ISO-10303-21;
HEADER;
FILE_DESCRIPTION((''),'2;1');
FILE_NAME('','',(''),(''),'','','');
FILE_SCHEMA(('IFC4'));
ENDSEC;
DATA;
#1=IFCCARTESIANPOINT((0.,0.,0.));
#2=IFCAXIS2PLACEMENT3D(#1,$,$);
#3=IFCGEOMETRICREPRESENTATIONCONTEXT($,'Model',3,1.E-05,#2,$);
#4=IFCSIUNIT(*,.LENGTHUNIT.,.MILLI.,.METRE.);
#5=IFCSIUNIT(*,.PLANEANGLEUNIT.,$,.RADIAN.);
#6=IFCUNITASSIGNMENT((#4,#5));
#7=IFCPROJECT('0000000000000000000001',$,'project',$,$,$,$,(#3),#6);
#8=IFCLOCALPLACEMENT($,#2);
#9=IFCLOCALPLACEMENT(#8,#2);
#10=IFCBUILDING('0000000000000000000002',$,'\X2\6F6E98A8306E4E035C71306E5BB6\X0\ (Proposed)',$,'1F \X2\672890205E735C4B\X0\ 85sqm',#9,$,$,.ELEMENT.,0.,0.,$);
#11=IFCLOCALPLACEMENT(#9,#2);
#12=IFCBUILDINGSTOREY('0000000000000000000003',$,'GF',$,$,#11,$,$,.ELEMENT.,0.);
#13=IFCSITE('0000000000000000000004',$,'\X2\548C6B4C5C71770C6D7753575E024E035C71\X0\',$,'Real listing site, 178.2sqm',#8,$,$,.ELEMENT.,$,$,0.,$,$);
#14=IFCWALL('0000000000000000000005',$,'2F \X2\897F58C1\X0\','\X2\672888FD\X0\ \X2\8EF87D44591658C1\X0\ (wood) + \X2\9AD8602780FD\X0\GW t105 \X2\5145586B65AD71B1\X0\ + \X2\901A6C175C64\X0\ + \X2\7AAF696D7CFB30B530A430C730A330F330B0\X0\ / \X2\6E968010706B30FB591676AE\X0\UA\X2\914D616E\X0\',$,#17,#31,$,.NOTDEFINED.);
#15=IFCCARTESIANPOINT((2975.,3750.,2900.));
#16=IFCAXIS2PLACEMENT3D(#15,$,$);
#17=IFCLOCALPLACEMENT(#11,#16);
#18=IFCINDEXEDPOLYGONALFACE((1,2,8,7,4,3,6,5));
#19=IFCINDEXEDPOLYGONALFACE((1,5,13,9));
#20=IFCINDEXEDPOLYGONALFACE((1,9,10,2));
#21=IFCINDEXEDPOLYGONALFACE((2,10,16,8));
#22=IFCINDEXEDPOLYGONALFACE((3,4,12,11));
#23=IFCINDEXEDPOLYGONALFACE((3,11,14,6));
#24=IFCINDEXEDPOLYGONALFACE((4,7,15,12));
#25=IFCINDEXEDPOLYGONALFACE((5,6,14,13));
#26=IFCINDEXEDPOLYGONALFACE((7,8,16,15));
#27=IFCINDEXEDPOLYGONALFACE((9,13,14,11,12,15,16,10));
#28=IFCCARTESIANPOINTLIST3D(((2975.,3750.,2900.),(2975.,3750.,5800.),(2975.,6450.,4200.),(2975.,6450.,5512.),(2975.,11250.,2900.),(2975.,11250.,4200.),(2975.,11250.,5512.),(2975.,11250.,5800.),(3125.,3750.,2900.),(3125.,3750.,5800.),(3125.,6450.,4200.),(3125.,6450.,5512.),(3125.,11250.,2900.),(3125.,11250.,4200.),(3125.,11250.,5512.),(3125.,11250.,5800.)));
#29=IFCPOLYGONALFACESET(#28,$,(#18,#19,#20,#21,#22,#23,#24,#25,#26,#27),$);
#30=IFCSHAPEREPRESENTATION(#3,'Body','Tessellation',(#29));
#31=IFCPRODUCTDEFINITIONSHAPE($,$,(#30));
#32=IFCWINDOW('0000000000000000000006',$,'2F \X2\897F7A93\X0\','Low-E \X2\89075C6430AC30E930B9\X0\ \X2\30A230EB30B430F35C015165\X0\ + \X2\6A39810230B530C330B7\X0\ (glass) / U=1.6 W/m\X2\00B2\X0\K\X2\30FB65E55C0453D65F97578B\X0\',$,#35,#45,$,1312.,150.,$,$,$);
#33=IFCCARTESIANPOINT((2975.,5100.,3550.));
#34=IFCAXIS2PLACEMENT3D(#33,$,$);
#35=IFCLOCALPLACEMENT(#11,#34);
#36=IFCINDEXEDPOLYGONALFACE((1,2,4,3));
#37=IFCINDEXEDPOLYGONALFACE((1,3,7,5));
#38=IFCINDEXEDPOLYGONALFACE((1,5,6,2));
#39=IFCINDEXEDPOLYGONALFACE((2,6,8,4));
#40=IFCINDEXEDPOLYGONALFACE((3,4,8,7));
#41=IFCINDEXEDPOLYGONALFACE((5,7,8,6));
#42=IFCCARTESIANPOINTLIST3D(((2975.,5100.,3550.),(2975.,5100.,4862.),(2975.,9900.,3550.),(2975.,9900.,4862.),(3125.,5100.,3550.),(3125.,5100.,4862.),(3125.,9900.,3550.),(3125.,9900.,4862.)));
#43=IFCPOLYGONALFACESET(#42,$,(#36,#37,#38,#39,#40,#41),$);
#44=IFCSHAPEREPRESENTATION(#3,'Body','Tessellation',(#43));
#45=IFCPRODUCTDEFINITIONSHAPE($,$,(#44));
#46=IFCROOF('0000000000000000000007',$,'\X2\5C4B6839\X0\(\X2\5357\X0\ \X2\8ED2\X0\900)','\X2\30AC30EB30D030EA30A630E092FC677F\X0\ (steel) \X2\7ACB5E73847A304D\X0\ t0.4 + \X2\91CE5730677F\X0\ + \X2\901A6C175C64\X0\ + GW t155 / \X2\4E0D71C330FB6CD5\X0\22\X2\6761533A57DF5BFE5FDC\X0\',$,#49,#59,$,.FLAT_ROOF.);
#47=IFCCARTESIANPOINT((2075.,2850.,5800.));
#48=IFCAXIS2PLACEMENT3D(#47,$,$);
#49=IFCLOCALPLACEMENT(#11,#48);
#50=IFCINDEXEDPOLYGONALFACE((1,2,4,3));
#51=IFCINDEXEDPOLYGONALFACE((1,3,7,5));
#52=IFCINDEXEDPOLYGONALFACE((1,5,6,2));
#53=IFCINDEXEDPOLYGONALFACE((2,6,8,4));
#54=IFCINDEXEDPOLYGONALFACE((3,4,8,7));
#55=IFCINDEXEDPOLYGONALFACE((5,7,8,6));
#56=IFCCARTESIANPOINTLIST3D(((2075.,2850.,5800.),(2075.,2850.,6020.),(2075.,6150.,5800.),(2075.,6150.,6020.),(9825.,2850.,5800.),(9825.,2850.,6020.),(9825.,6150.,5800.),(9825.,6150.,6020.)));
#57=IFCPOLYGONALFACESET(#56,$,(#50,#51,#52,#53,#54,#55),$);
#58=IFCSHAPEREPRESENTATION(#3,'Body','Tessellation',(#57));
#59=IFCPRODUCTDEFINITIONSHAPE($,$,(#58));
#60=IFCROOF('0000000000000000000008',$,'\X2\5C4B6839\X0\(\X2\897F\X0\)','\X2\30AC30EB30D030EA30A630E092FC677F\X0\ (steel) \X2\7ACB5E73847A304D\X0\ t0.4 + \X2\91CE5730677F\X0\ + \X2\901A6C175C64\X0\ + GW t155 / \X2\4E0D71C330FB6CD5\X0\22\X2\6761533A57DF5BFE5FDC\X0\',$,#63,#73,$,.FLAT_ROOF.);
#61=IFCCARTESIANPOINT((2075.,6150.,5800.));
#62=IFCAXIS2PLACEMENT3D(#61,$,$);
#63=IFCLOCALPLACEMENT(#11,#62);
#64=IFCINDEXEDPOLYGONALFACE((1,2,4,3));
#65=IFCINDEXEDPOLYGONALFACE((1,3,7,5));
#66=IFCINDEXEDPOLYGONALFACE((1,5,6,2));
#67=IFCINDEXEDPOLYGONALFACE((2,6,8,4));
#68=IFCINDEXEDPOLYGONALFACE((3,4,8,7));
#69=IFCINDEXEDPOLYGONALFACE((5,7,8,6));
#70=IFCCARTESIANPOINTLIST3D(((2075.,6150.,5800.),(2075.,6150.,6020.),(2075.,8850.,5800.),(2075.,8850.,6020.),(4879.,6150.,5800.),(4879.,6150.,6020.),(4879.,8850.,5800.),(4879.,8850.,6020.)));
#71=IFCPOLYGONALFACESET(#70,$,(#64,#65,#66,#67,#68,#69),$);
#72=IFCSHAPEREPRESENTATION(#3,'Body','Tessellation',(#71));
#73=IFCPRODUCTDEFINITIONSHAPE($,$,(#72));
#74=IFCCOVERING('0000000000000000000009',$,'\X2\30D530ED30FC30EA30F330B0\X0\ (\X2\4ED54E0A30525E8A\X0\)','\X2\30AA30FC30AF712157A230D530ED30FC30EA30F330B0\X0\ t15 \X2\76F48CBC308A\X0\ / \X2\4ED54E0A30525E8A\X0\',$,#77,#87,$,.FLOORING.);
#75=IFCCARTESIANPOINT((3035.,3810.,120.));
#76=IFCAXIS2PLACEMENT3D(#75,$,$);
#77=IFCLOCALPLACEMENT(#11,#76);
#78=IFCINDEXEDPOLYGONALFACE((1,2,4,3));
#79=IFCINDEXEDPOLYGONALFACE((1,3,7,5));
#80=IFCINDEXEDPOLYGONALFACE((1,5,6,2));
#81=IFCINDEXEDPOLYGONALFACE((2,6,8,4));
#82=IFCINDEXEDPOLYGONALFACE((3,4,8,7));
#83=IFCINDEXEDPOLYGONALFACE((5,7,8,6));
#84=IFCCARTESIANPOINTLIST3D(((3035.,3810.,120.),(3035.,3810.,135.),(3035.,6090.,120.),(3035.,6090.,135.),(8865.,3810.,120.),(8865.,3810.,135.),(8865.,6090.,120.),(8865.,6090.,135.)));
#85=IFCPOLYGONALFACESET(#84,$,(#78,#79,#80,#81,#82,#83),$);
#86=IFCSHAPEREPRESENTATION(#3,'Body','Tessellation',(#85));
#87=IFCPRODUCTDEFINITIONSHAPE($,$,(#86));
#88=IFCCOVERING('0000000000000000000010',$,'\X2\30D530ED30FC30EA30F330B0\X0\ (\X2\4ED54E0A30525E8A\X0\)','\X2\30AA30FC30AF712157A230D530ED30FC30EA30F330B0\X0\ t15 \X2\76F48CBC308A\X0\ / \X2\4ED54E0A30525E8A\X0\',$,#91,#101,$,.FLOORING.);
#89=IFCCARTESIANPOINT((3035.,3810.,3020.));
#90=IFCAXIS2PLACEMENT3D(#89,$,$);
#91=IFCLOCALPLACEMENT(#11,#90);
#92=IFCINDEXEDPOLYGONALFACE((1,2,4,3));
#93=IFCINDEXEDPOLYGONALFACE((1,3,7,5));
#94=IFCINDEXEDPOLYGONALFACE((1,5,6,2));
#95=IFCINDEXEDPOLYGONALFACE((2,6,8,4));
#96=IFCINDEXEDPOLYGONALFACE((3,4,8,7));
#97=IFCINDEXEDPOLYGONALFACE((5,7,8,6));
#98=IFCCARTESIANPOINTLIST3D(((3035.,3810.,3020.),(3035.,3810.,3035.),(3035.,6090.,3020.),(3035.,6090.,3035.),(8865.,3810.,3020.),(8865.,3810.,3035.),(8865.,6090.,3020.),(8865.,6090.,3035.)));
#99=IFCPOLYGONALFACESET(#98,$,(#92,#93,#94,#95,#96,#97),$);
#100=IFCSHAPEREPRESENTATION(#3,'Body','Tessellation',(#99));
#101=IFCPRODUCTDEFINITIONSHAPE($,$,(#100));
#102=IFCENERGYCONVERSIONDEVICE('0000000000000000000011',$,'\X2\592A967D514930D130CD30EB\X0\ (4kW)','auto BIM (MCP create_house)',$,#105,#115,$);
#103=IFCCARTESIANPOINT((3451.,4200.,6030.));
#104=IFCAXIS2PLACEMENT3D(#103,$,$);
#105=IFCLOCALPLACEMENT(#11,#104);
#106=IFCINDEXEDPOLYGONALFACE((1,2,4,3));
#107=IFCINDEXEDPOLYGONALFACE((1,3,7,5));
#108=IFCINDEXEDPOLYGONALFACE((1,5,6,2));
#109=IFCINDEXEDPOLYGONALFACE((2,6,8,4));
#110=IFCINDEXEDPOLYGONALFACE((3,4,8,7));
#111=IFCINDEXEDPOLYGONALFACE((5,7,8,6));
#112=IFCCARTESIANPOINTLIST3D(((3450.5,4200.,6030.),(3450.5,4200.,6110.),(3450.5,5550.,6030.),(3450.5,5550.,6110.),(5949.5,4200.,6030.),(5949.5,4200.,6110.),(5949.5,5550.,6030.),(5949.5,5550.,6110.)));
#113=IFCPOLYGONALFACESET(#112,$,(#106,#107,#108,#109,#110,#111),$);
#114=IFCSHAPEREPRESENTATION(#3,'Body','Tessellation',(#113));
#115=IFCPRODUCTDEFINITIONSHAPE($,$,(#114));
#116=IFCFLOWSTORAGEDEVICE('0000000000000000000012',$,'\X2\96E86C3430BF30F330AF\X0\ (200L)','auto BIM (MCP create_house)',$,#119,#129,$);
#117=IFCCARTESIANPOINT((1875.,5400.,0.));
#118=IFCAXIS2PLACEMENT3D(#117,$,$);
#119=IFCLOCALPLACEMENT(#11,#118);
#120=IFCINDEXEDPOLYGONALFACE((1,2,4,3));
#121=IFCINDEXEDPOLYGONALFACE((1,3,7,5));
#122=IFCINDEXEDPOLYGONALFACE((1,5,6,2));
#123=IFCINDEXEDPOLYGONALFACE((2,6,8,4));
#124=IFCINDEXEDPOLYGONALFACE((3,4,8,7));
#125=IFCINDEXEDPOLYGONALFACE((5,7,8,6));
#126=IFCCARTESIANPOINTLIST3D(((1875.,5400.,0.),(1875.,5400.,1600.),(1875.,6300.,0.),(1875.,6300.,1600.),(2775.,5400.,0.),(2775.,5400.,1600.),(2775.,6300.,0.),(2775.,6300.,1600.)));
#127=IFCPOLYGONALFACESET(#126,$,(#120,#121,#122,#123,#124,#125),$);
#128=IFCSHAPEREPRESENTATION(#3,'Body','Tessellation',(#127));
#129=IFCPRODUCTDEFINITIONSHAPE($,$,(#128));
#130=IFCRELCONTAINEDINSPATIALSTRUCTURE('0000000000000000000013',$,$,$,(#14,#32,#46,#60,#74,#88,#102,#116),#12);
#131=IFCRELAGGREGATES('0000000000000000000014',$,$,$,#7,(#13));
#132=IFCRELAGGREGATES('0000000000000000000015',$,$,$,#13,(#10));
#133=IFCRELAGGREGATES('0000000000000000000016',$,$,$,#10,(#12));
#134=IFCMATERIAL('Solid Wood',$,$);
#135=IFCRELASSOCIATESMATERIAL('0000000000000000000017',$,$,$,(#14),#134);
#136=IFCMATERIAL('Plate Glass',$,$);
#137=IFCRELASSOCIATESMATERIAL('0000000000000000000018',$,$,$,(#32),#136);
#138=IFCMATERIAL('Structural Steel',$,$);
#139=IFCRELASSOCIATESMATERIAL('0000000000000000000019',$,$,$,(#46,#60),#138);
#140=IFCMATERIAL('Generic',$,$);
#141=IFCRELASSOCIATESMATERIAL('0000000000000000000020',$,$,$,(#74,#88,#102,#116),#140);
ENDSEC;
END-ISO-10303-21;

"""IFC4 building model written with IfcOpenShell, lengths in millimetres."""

from ifc_helpers import new_model, si_unit, frame, frame_2d, origin, place, context, project, spatial, rectangle, extrude, material, element, fill, save


model = new_model("IFC4")

# Units and contexts
model_context = context("Model", 3, precision=1e-05, world=origin())
ifc_project = project(units=[si_unit("LENGTHUNIT", "METRE", prefix="MILLI"), si_unit("PLANEANGLEUNIT", "RADIAN")], contexts=[model_context])

# Site, building, storey
site_placement = place(None, origin())
site = spatial("IfcSite", under=ifc_project, at=site_placement, Name="和歌山県海南市七山", ObjectType="Real listing site, 178.2sqm", CompositionType="ELEMENT", RefElevation=0.0)
building_placement = place(site_placement, origin())
building = spatial("IfcBuilding", under=site, at=building_placement, Name="潮風の七山の家 (Proposed)", ObjectType="1F 木造平屋 85sqm", CompositionType="ELEMENT", ElevationOfRefHeight=0.0, ElevationOfTerrain=0.0)
storey_placement = place(building_placement, origin())
storey = spatial("IfcBuildingStorey", under=building, at=storey_placement, Name="GF", CompositionType="ELEMENT", Elevation=0.0)

# Shared definitions
ifc_material_1 = material(Name="Solid Wood")
ifc_material_2 = material(Name="Generic")

# Shared definitions
ifc_material_3 = material(Name="Plate Glass")

# Wall, opening, window
wall_1_placement = place(storey_placement, frame((2975.0, 3750.0, 2900.0)))
wall_1 = element("IfcWall", 1, at=wall_1_placement, inside=storey, material=ifc_material_1, Name="2F 西壁", Description="木製 軸組外壁 (wood) + 高性能GW t105 充填断熱 + 通気層 + 窯業系サイディング / 準耐火・外皮UA配慮", PredefinedType="NOTDEFINED", context=model_context, shape_type="SweptSolid", body=[
    extrude(rectangle(XDim=150.0, YDim=7500.0, at=frame_2d((75.0, 3750.0))), frame((2975.0, 3750.0, 2900.0)), (0.0, 0.0, 1.0), 2900.0),
])
opening_1_placement = place(storey_placement, frame((2975.0, 5100.0, 3550.0)))
opening_1 = element("IfcOpeningElement", 2, at=opening_1_placement, cuts=wall_1, PredefinedType="NOTDEFINED", context=model_context, shape_type="SweptSolid", body=[
    extrude(rectangle(XDim=150.0, YDim=4800.0, at=frame_2d((75.0, 2400.0))), frame((2975.0, 5100.0, 3550.0)), (0.0, 0.0, 1.0), 1312.0),
])
window_1_placement = place(storey_placement, frame((2975.0, 5100.0, 3550.0)))
window_1 = element("IfcWindow", 3, at=window_1_placement, inside=storey, material=ifc_material_3, Name="2F 西窓", Description="Low-E 複層ガラス アルゴン封入 + 樹脂サッシ (glass) / U=1.6 W/m²K・日射取得型", OverallHeight=1312.0, OverallWidth=150.0, context=model_context, shape_type="SweptSolid", body=[
    extrude(rectangle(XDim=150.0, YDim=4800.0, at=frame_2d((75.0, 2400.0))), frame((2975.0, 5100.0, 3550.0)), (0.0, 0.0, 1.0), 1312.0),
])
fill(opening_1, window_1)

# Roofs
ifc_material_4 = material(Name="Structural Steel")
roof_1_placement = place(storey_placement, frame((2075.0, 2850.0, 5800.0)))
element("IfcRoof", 4, at=roof_1_placement, inside=storey, material=ifc_material_4, Name="屋根(南 軒900)", Description="ガルバリウム鋼板 (steel) 立平葺き t0.4 + 野地板 + 通気層 + GW t155 / 不燃・法22条区域対応", PredefinedType="FLAT_ROOF", context=model_context, shape_type="SweptSolid", body=[
    extrude(rectangle(XDim=7750.0, YDim=3300.0, at=frame_2d((3875.0, 1650.0))), frame((2075.0, 2850.0, 5800.0)), (0.0, 0.0, 1.0), 220.0),
])
roof_2_placement = place(storey_placement, frame((2075.0, 6150.0, 5800.0)))
element("IfcRoof", 5, at=roof_2_placement, inside=storey, material=ifc_material_4, Name="屋根(西)", Description="ガルバリウム鋼板 (steel) 立平葺き t0.4 + 野地板 + 通気層 + GW t155 / 不燃・法22条区域対応", PredefinedType="FLAT_ROOF", context=model_context, shape_type="SweptSolid", body=[
    extrude(rectangle(XDim=2804.0, YDim=2700.0, at=frame_2d((1402.0, 1350.0))), frame((2075.0, 6150.0, 5800.0)), (0.0, 0.0, 1.0), 220.0),
])

# Coverings
covering_1_placement = place(storey_placement, frame((3035.0, 3810.0, 120.0)))
element("IfcCovering", 6, at=covering_1_placement, inside=storey, material=ifc_material_2, Name="フローリング (仕上げ床)", Description="オーク無垢フローリング t15 直貼り / 仕上げ床", PredefinedType="FLOORING", context=model_context, shape_type="SweptSolid", body=[
    extrude(rectangle(XDim=5830.0, YDim=2280.0, at=frame_2d((2915.0, 1140.0))), frame((3035.0, 3810.0, 120.0)), (0.0, 0.0, 1.0), 15.0),
])
covering_2_placement = place(storey_placement, frame((3035.0, 3810.0, 3020.0)))
element("IfcCovering", 7, at=covering_2_placement, inside=storey, material=ifc_material_2, Name="フローリング (仕上げ床)", Description="オーク無垢フローリング t15 直貼り / 仕上げ床", PredefinedType="FLOORING", context=model_context, shape_type="SweptSolid", body=[
    extrude(rectangle(XDim=5830.0, YDim=2280.0, at=frame_2d((2915.0, 1140.0))), frame((3035.0, 3810.0, 3020.0)), (0.0, 0.0, 1.0), 15.0),
])

# Energy conversion device
energy_conversion_device_placement = place(storey_placement, frame((3451.0, 4200.0, 6030.0)))
element("IfcEnergyConversionDevice", 8, at=energy_conversion_device_placement, inside=storey, material=ifc_material_2, Name="太陽光パネル (4kW)", Description="auto BIM (MCP create_house)", context=model_context, shape_type="SweptSolid", body=[
    extrude(rectangle(XDim=2499.0, YDim=1350.0, at=frame_2d((1249.0, 675.0))), frame((3451.0, 4200.0, 6030.0)), (0.0, 0.0, 1.0), 80.0),
])

# Flow storage device
flow_storage_device_placement = place(storey_placement, frame((1875.0, 5400.0, 0.0)))
element("IfcFlowStorageDevice", 9, at=flow_storage_device_placement, inside=storey, material=ifc_material_2, Name="雨水タンク (200L)", Description="auto BIM (MCP create_house)", context=model_context, shape_type="SweptSolid", body=[
    extrude(rectangle(XDim=900.0, YDim=900.0, at=frame_2d((450.0, 450.0))), frame((1875.0, 5400.0, 0.0)), (0.0, 0.0, 1.0), 1600.0),
])

save(model, "model.ifc")
